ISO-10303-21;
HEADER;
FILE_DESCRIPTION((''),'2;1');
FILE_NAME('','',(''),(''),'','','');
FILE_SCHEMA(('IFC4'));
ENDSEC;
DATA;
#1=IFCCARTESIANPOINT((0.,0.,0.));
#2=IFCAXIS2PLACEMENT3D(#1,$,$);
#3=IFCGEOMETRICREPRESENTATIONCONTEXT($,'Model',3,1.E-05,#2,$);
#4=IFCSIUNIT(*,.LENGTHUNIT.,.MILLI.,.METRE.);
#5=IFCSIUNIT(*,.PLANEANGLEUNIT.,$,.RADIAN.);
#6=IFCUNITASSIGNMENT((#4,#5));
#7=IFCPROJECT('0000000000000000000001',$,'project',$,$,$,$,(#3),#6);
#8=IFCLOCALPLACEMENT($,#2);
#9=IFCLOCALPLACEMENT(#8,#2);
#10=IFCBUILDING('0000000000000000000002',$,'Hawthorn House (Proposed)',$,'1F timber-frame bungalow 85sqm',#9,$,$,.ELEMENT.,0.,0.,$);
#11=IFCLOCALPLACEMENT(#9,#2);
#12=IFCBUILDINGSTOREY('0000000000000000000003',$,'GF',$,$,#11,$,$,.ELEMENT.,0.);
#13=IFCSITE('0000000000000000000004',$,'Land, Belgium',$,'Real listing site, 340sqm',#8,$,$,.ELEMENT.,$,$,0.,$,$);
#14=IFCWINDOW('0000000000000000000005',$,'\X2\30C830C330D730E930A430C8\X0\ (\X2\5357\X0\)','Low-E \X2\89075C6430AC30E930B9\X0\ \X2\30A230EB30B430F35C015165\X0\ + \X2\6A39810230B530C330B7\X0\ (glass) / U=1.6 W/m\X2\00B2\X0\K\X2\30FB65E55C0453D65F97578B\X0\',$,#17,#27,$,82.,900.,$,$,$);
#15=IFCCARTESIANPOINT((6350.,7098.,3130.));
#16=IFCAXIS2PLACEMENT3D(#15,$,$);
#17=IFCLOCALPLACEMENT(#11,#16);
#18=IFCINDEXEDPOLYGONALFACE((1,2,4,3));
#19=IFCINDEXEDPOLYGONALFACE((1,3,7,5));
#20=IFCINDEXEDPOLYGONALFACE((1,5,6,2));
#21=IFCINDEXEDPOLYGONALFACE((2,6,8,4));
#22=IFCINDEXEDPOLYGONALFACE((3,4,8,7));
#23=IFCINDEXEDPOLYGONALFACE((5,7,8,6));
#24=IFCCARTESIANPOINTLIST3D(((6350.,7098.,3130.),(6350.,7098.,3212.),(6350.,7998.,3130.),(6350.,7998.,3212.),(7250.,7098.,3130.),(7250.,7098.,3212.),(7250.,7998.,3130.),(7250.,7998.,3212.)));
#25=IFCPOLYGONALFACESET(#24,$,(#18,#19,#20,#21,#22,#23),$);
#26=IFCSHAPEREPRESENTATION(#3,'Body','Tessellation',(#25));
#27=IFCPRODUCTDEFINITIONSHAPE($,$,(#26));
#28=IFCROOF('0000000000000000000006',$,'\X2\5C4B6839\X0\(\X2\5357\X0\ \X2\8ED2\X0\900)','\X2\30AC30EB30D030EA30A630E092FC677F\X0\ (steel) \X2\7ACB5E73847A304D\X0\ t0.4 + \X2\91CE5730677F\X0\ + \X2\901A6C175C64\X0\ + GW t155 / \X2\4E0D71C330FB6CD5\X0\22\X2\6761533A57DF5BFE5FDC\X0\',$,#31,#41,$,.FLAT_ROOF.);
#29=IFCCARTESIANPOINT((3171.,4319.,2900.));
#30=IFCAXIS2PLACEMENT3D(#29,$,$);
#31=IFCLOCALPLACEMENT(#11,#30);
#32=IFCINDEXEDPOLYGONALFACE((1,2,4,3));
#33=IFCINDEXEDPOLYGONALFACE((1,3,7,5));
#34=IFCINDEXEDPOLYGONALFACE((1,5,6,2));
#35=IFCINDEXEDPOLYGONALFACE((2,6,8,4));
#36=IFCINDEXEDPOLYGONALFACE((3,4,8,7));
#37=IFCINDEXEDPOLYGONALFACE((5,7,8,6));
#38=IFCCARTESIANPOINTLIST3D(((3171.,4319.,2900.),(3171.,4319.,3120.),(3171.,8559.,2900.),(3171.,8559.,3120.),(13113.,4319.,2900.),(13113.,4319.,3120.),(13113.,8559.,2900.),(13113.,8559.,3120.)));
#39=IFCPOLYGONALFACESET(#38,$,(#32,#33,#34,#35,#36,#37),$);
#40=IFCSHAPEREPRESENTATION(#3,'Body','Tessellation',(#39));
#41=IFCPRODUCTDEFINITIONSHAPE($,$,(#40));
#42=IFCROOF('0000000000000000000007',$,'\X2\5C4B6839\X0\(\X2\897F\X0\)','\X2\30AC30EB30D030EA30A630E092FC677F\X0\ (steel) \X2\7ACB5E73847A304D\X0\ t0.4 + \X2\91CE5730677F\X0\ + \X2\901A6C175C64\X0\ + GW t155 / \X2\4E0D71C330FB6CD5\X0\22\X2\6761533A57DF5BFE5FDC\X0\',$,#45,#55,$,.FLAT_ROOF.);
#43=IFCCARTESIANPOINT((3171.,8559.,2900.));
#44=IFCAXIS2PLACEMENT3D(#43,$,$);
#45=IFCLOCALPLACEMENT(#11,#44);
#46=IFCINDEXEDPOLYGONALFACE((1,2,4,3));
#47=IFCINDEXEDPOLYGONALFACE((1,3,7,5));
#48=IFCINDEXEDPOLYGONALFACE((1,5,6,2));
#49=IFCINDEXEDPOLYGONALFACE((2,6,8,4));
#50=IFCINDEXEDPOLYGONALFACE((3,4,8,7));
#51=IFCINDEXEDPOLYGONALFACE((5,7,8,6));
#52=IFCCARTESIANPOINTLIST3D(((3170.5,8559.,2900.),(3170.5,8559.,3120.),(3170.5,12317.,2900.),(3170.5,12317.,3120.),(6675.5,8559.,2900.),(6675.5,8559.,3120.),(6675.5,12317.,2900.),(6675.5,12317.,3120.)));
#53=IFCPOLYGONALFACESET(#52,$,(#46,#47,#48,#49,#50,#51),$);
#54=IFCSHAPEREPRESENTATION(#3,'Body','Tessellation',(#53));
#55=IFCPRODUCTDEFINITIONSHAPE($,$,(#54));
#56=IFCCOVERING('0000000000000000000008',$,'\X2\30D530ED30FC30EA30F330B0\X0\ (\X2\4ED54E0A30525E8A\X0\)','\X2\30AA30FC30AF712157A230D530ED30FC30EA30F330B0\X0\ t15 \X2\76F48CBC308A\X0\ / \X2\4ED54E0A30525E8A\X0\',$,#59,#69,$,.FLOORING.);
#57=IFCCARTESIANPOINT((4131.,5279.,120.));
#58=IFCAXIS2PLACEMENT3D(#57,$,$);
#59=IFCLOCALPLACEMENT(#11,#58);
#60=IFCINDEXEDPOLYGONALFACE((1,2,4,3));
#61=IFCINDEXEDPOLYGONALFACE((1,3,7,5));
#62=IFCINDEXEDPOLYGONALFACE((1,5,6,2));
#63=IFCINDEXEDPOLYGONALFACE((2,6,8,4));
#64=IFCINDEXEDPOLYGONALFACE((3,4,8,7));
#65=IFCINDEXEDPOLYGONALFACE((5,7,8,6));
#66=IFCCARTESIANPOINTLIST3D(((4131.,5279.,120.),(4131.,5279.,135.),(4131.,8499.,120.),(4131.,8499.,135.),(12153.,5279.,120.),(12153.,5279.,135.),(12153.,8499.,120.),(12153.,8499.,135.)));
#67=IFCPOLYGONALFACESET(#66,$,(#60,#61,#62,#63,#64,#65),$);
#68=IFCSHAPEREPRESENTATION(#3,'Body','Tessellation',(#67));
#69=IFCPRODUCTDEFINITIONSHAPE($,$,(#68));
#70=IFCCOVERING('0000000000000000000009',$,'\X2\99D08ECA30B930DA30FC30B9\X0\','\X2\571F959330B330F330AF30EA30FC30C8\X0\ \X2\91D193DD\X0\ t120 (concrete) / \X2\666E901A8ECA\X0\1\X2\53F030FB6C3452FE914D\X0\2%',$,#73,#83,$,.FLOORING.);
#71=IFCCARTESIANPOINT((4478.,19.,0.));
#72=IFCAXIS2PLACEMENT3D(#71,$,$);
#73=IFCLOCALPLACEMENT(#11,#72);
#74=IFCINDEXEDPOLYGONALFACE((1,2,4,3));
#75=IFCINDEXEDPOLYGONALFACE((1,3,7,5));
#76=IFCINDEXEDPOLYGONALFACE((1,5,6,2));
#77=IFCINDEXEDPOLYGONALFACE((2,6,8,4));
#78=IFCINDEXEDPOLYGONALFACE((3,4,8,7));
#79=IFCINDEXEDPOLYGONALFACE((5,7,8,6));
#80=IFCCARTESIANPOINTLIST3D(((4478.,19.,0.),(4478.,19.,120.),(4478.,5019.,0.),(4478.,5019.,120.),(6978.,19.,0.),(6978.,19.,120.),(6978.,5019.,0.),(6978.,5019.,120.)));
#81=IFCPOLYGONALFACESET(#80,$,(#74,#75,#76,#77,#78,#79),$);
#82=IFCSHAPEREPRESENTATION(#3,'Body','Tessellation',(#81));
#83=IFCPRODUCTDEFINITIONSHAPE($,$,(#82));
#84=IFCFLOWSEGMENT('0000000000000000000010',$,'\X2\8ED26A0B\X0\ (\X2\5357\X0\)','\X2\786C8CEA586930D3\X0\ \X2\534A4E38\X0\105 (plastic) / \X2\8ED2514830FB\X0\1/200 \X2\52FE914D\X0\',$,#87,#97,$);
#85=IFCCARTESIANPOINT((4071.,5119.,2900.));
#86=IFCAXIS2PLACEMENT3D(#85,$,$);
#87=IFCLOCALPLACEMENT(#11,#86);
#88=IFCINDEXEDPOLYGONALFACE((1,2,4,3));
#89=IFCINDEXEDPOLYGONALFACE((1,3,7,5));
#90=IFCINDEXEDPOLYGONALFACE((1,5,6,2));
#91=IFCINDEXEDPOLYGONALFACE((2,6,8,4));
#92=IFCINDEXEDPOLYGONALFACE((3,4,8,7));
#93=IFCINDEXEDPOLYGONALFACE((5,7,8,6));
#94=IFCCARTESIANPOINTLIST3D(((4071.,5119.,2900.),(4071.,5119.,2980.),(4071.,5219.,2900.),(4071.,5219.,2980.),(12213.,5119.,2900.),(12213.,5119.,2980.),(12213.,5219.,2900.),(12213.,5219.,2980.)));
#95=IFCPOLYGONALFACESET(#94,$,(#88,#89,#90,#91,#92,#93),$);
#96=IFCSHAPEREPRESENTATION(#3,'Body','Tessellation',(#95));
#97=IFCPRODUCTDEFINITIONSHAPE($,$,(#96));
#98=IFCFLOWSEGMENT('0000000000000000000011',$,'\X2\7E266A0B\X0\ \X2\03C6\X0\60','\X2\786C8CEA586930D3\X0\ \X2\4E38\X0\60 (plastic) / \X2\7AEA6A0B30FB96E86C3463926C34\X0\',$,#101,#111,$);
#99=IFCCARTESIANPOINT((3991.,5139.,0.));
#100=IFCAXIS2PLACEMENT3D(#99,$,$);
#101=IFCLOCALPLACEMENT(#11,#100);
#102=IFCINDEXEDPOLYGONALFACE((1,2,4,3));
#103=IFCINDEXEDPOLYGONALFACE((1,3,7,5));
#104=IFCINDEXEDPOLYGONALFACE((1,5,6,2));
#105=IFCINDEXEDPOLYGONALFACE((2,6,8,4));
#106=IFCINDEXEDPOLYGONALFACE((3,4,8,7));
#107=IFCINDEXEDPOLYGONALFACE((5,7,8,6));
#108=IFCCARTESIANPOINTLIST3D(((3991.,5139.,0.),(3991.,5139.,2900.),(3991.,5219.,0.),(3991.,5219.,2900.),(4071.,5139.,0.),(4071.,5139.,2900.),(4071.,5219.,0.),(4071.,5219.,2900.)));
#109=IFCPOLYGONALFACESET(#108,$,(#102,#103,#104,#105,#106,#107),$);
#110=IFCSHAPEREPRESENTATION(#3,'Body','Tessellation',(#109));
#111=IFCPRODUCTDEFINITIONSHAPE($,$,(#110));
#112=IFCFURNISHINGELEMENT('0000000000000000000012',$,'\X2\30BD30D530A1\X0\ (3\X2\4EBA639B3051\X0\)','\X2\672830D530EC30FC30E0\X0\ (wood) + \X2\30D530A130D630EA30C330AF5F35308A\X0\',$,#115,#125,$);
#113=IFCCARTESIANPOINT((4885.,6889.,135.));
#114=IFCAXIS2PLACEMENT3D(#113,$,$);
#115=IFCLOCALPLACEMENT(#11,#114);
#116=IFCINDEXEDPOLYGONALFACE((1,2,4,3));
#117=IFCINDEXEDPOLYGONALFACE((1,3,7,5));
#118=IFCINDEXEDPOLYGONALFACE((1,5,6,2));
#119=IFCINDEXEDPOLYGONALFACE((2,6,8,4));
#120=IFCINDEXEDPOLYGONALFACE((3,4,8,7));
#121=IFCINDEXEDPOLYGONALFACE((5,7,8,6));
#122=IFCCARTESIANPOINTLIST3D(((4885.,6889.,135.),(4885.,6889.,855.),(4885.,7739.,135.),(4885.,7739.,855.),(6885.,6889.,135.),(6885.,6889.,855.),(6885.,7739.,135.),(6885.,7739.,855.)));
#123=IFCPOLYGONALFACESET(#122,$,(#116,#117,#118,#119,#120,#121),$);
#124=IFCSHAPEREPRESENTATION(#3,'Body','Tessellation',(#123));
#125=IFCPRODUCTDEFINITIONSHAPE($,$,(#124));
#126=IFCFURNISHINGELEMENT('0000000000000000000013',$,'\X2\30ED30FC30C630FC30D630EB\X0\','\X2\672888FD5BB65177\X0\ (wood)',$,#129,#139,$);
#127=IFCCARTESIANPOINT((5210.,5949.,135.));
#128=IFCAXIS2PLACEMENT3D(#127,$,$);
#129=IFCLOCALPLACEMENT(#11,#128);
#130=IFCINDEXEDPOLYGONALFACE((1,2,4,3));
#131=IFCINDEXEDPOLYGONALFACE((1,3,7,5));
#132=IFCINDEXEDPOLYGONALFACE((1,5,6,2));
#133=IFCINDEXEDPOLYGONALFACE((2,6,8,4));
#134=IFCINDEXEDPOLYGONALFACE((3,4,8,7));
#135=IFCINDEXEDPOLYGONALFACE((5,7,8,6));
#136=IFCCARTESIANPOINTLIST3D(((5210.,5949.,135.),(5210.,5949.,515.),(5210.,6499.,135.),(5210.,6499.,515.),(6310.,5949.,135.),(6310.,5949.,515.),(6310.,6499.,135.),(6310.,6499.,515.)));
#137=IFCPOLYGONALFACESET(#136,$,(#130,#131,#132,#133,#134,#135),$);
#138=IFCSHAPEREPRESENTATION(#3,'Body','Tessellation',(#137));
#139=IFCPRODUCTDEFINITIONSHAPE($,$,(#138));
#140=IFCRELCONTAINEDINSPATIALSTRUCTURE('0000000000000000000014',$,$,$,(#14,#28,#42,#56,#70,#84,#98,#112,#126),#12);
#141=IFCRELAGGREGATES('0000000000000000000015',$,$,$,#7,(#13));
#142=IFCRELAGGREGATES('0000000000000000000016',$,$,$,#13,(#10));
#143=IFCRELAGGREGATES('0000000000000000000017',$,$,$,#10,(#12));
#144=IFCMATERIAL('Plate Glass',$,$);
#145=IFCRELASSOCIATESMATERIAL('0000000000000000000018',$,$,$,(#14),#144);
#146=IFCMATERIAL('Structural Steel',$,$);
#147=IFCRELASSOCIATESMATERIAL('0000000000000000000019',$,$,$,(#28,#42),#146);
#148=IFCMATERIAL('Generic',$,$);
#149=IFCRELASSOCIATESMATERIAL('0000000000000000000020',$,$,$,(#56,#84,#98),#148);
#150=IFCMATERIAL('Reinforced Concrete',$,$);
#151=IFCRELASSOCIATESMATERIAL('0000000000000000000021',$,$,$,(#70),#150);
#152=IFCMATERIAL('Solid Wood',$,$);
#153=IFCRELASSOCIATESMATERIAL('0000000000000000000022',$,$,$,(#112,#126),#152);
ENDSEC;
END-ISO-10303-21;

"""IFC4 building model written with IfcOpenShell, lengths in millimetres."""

from ifc_helpers import new_model, si_unit, frame, frame_2d, origin, place, context, project, spatial, rectangle, extrude, material, element, save


model = new_model("IFC4")

# Units and contexts
model_context = context("Model", 3, precision=1e-05, world=origin())
ifc_project = project(units=[si_unit("LENGTHUNIT", "METRE", prefix="MILLI"), si_unit("PLANEANGLEUNIT", "RADIAN")], contexts=[model_context])

# Site, building, storey
site_placement = place(None, origin())
site = spatial("IfcSite", under=ifc_project, at=site_placement, Name="Land, Belgium", ObjectType="Real listing site, 340sqm", CompositionType="ELEMENT", RefElevation=0.0)
building_placement = place(site_placement, origin())
building = spatial("IfcBuilding", under=site, at=building_placement, Name="Hawthorn House (Proposed)", ObjectType="1F timber-frame bungalow 85sqm", CompositionType="ELEMENT", ElevationOfRefHeight=0.0, ElevationOfTerrain=0.0)
storey_placement = place(building_placement, origin())
storey = spatial("IfcBuildingStorey", under=building, at=storey_placement, Name="GF", CompositionType="ELEMENT", Elevation=0.0)

# Shared definitions
ifc_material_1 = material(Name="Solid Wood")

# Shared definitions
ifc_material_2 = material(Name="Reinforced Concrete")

# Shared definitions
ifc_material_3 = material(Name="Plate Glass")

# Window
window_1_placement = place(storey_placement, frame((6350.0, 7098.0, 3130.0)))
element("IfcWindow", 1, at=window_1_placement, inside=storey, material=ifc_material_3, Name="トップライト (南)", Description="Low-E 複層ガラス アルゴン封入 + 樹脂サッシ (glass) / U=1.6 W/m²K・日射取得型", OverallHeight=82.0, OverallWidth=900.0, context=model_context, shape_type="SweptSolid", body=[
    extrude(rectangle(XDim=900.0, YDim=900.0, at=frame_2d((450.0, 450.0))), frame((6350.0, 7098.0, 3130.0)), (0.0, 0.0, 1.0), 82.0),
])

# Roofs
ifc_material_4 = material(Name="Structural Steel")
roof_1_placement = place(storey_placement, frame((3171.0, 4319.0, 2900.0)))
element("IfcRoof", 2, at=roof_1_placement, inside=storey, material=ifc_material_4, Name="屋根(南 軒900)", Description="ガルバリウム鋼板 (steel) 立平葺き t0.4 + 野地板 + 通気層 + GW t155 / 不燃・法22条区域対応", PredefinedType="FLAT_ROOF", context=model_context, shape_type="SweptSolid", body=[
    extrude(rectangle(XDim=9942.0, YDim=4240.0, at=frame_2d((4971.0, 2120.0))), frame((3171.0, 4319.0, 2900.0)), (0.0, 0.0, 1.0), 220.0),
])
roof_2_placement = place(storey_placement, frame((3171.0, 8559.0, 2900.0)))
element("IfcRoof", 3, at=roof_2_placement, inside=storey, material=ifc_material_4, Name="屋根(西)", Description="ガルバリウム鋼板 (steel) 立平葺き t0.4 + 野地板 + 通気層 + GW t155 / 不燃・法22条区域対応", PredefinedType="FLAT_ROOF", context=model_context, shape_type="SweptSolid", body=[
    extrude(rectangle(XDim=3505.0, YDim=3758.0, at=frame_2d((1752.0, 1879.0))), frame((3171.0, 8559.0, 2900.0)), (0.0, 0.0, 1.0), 220.0),
])

# Coverings
ifc_material_5 = material(Name="Generic")
covering_1_placement = place(storey_placement, frame((4131.0, 5279.0, 120.0)))
element("IfcCovering", 4, at=covering_1_placement, inside=storey, material=ifc_material_5, Name="フローリング (仕上げ床)", Description="オーク無垢フローリング t15 直貼り / 仕上げ床", PredefinedType="FLOORING", context=model_context, shape_type="SweptSolid", body=[
    extrude(rectangle(XDim=8022.0, YDim=3220.0, at=frame_2d((4011.0, 1610.0))), frame((4131.0, 5279.0, 120.0)), (0.0, 0.0, 1.0), 15.0),
])
covering_2_placement = place(storey_placement, frame((4478.0, 19.0, 0.0)))
element("IfcCovering", 5, at=covering_2_placement, inside=storey, material=ifc_material_2, Name="駐車スペース", Description="土間コンクリート 金鏝 t120 (concrete) / 普通車1台・水勾配2%", PredefinedType="FLOORING", context=model_context, shape_type="SweptSolid", body=[
    extrude(rectangle(XDim=2500.0, YDim=5000.0, at=frame_2d((1250.0, 2500.0))), frame((4478.0, 19.0, 0.0)), (0.0, 0.0, 1.0), 120.0),
])

# Flow segments
flow_segment_1_placement = place(storey_placement, frame((4071.0, 5119.0, 2900.0)))
element("IfcFlowSegment", 6, at=flow_segment_1_placement, inside=storey, material=ifc_material_5, Name="軒樋 (南)", Description="硬質塩ビ 半丸105 (plastic) / 軒先・1/200 勾配", context=model_context, shape_type="SweptSolid", body=[
    extrude(rectangle(XDim=8142.0, YDim=100.0, at=frame_2d((4071.0, 50.0))), frame((4071.0, 5119.0, 2900.0)), (0.0, 0.0, 1.0), 80.0),
])
flow_segment_2_placement = place(storey_placement, frame((3991.0, 5139.0, 0.0)))
element("IfcFlowSegment", 7, at=flow_segment_2_placement, inside=storey, material=ifc_material_5, Name="縦樋 φ60", Description="硬質塩ビ 丸60 (plastic) / 竪樋・雨水排水", context=model_context, shape_type="SweptSolid", body=[
    extrude(rectangle(XDim=80.0, YDim=80.0, at=frame_2d((40.0, 40.0))), frame((3991.0, 5139.0, 0.0)), (0.0, 0.0, 1.0), 2900.0),
])

# Furnishing elements
furnishing_1_placement = place(storey_placement, frame((4885.0, 6889.0, 135.0)))
element("IfcFurnishingElement", 8, at=furnishing_1_placement, inside=storey, material=ifc_material_1, Name="ソファ (3人掛け)", Description="木フレーム (wood) + ファブリック張り", context=model_context, shape_type="SweptSolid", body=[
    extrude(rectangle(XDim=2000.0, YDim=850.0, at=frame_2d((1000.0, 425.0))), frame((4885.0, 6889.0, 135.0)), (0.0, 0.0, 1.0), 720.0),
])
furnishing_2_placement = place(storey_placement, frame((5210.0, 5949.0, 135.0)))
element("IfcFurnishingElement", 9, at=furnishing_2_placement, inside=storey, material=ifc_material_1, Name="ローテーブル", Description="木製家具 (wood)", context=model_context, shape_type="SweptSolid", body=[
    extrude(rectangle(XDim=1100.0, YDim=550.0, at=frame_2d((550.0, 275.0))), frame((5210.0, 5949.0, 135.0)), (0.0, 0.0, 1.0), 380.0),
])

save(model, "model.ifc")
